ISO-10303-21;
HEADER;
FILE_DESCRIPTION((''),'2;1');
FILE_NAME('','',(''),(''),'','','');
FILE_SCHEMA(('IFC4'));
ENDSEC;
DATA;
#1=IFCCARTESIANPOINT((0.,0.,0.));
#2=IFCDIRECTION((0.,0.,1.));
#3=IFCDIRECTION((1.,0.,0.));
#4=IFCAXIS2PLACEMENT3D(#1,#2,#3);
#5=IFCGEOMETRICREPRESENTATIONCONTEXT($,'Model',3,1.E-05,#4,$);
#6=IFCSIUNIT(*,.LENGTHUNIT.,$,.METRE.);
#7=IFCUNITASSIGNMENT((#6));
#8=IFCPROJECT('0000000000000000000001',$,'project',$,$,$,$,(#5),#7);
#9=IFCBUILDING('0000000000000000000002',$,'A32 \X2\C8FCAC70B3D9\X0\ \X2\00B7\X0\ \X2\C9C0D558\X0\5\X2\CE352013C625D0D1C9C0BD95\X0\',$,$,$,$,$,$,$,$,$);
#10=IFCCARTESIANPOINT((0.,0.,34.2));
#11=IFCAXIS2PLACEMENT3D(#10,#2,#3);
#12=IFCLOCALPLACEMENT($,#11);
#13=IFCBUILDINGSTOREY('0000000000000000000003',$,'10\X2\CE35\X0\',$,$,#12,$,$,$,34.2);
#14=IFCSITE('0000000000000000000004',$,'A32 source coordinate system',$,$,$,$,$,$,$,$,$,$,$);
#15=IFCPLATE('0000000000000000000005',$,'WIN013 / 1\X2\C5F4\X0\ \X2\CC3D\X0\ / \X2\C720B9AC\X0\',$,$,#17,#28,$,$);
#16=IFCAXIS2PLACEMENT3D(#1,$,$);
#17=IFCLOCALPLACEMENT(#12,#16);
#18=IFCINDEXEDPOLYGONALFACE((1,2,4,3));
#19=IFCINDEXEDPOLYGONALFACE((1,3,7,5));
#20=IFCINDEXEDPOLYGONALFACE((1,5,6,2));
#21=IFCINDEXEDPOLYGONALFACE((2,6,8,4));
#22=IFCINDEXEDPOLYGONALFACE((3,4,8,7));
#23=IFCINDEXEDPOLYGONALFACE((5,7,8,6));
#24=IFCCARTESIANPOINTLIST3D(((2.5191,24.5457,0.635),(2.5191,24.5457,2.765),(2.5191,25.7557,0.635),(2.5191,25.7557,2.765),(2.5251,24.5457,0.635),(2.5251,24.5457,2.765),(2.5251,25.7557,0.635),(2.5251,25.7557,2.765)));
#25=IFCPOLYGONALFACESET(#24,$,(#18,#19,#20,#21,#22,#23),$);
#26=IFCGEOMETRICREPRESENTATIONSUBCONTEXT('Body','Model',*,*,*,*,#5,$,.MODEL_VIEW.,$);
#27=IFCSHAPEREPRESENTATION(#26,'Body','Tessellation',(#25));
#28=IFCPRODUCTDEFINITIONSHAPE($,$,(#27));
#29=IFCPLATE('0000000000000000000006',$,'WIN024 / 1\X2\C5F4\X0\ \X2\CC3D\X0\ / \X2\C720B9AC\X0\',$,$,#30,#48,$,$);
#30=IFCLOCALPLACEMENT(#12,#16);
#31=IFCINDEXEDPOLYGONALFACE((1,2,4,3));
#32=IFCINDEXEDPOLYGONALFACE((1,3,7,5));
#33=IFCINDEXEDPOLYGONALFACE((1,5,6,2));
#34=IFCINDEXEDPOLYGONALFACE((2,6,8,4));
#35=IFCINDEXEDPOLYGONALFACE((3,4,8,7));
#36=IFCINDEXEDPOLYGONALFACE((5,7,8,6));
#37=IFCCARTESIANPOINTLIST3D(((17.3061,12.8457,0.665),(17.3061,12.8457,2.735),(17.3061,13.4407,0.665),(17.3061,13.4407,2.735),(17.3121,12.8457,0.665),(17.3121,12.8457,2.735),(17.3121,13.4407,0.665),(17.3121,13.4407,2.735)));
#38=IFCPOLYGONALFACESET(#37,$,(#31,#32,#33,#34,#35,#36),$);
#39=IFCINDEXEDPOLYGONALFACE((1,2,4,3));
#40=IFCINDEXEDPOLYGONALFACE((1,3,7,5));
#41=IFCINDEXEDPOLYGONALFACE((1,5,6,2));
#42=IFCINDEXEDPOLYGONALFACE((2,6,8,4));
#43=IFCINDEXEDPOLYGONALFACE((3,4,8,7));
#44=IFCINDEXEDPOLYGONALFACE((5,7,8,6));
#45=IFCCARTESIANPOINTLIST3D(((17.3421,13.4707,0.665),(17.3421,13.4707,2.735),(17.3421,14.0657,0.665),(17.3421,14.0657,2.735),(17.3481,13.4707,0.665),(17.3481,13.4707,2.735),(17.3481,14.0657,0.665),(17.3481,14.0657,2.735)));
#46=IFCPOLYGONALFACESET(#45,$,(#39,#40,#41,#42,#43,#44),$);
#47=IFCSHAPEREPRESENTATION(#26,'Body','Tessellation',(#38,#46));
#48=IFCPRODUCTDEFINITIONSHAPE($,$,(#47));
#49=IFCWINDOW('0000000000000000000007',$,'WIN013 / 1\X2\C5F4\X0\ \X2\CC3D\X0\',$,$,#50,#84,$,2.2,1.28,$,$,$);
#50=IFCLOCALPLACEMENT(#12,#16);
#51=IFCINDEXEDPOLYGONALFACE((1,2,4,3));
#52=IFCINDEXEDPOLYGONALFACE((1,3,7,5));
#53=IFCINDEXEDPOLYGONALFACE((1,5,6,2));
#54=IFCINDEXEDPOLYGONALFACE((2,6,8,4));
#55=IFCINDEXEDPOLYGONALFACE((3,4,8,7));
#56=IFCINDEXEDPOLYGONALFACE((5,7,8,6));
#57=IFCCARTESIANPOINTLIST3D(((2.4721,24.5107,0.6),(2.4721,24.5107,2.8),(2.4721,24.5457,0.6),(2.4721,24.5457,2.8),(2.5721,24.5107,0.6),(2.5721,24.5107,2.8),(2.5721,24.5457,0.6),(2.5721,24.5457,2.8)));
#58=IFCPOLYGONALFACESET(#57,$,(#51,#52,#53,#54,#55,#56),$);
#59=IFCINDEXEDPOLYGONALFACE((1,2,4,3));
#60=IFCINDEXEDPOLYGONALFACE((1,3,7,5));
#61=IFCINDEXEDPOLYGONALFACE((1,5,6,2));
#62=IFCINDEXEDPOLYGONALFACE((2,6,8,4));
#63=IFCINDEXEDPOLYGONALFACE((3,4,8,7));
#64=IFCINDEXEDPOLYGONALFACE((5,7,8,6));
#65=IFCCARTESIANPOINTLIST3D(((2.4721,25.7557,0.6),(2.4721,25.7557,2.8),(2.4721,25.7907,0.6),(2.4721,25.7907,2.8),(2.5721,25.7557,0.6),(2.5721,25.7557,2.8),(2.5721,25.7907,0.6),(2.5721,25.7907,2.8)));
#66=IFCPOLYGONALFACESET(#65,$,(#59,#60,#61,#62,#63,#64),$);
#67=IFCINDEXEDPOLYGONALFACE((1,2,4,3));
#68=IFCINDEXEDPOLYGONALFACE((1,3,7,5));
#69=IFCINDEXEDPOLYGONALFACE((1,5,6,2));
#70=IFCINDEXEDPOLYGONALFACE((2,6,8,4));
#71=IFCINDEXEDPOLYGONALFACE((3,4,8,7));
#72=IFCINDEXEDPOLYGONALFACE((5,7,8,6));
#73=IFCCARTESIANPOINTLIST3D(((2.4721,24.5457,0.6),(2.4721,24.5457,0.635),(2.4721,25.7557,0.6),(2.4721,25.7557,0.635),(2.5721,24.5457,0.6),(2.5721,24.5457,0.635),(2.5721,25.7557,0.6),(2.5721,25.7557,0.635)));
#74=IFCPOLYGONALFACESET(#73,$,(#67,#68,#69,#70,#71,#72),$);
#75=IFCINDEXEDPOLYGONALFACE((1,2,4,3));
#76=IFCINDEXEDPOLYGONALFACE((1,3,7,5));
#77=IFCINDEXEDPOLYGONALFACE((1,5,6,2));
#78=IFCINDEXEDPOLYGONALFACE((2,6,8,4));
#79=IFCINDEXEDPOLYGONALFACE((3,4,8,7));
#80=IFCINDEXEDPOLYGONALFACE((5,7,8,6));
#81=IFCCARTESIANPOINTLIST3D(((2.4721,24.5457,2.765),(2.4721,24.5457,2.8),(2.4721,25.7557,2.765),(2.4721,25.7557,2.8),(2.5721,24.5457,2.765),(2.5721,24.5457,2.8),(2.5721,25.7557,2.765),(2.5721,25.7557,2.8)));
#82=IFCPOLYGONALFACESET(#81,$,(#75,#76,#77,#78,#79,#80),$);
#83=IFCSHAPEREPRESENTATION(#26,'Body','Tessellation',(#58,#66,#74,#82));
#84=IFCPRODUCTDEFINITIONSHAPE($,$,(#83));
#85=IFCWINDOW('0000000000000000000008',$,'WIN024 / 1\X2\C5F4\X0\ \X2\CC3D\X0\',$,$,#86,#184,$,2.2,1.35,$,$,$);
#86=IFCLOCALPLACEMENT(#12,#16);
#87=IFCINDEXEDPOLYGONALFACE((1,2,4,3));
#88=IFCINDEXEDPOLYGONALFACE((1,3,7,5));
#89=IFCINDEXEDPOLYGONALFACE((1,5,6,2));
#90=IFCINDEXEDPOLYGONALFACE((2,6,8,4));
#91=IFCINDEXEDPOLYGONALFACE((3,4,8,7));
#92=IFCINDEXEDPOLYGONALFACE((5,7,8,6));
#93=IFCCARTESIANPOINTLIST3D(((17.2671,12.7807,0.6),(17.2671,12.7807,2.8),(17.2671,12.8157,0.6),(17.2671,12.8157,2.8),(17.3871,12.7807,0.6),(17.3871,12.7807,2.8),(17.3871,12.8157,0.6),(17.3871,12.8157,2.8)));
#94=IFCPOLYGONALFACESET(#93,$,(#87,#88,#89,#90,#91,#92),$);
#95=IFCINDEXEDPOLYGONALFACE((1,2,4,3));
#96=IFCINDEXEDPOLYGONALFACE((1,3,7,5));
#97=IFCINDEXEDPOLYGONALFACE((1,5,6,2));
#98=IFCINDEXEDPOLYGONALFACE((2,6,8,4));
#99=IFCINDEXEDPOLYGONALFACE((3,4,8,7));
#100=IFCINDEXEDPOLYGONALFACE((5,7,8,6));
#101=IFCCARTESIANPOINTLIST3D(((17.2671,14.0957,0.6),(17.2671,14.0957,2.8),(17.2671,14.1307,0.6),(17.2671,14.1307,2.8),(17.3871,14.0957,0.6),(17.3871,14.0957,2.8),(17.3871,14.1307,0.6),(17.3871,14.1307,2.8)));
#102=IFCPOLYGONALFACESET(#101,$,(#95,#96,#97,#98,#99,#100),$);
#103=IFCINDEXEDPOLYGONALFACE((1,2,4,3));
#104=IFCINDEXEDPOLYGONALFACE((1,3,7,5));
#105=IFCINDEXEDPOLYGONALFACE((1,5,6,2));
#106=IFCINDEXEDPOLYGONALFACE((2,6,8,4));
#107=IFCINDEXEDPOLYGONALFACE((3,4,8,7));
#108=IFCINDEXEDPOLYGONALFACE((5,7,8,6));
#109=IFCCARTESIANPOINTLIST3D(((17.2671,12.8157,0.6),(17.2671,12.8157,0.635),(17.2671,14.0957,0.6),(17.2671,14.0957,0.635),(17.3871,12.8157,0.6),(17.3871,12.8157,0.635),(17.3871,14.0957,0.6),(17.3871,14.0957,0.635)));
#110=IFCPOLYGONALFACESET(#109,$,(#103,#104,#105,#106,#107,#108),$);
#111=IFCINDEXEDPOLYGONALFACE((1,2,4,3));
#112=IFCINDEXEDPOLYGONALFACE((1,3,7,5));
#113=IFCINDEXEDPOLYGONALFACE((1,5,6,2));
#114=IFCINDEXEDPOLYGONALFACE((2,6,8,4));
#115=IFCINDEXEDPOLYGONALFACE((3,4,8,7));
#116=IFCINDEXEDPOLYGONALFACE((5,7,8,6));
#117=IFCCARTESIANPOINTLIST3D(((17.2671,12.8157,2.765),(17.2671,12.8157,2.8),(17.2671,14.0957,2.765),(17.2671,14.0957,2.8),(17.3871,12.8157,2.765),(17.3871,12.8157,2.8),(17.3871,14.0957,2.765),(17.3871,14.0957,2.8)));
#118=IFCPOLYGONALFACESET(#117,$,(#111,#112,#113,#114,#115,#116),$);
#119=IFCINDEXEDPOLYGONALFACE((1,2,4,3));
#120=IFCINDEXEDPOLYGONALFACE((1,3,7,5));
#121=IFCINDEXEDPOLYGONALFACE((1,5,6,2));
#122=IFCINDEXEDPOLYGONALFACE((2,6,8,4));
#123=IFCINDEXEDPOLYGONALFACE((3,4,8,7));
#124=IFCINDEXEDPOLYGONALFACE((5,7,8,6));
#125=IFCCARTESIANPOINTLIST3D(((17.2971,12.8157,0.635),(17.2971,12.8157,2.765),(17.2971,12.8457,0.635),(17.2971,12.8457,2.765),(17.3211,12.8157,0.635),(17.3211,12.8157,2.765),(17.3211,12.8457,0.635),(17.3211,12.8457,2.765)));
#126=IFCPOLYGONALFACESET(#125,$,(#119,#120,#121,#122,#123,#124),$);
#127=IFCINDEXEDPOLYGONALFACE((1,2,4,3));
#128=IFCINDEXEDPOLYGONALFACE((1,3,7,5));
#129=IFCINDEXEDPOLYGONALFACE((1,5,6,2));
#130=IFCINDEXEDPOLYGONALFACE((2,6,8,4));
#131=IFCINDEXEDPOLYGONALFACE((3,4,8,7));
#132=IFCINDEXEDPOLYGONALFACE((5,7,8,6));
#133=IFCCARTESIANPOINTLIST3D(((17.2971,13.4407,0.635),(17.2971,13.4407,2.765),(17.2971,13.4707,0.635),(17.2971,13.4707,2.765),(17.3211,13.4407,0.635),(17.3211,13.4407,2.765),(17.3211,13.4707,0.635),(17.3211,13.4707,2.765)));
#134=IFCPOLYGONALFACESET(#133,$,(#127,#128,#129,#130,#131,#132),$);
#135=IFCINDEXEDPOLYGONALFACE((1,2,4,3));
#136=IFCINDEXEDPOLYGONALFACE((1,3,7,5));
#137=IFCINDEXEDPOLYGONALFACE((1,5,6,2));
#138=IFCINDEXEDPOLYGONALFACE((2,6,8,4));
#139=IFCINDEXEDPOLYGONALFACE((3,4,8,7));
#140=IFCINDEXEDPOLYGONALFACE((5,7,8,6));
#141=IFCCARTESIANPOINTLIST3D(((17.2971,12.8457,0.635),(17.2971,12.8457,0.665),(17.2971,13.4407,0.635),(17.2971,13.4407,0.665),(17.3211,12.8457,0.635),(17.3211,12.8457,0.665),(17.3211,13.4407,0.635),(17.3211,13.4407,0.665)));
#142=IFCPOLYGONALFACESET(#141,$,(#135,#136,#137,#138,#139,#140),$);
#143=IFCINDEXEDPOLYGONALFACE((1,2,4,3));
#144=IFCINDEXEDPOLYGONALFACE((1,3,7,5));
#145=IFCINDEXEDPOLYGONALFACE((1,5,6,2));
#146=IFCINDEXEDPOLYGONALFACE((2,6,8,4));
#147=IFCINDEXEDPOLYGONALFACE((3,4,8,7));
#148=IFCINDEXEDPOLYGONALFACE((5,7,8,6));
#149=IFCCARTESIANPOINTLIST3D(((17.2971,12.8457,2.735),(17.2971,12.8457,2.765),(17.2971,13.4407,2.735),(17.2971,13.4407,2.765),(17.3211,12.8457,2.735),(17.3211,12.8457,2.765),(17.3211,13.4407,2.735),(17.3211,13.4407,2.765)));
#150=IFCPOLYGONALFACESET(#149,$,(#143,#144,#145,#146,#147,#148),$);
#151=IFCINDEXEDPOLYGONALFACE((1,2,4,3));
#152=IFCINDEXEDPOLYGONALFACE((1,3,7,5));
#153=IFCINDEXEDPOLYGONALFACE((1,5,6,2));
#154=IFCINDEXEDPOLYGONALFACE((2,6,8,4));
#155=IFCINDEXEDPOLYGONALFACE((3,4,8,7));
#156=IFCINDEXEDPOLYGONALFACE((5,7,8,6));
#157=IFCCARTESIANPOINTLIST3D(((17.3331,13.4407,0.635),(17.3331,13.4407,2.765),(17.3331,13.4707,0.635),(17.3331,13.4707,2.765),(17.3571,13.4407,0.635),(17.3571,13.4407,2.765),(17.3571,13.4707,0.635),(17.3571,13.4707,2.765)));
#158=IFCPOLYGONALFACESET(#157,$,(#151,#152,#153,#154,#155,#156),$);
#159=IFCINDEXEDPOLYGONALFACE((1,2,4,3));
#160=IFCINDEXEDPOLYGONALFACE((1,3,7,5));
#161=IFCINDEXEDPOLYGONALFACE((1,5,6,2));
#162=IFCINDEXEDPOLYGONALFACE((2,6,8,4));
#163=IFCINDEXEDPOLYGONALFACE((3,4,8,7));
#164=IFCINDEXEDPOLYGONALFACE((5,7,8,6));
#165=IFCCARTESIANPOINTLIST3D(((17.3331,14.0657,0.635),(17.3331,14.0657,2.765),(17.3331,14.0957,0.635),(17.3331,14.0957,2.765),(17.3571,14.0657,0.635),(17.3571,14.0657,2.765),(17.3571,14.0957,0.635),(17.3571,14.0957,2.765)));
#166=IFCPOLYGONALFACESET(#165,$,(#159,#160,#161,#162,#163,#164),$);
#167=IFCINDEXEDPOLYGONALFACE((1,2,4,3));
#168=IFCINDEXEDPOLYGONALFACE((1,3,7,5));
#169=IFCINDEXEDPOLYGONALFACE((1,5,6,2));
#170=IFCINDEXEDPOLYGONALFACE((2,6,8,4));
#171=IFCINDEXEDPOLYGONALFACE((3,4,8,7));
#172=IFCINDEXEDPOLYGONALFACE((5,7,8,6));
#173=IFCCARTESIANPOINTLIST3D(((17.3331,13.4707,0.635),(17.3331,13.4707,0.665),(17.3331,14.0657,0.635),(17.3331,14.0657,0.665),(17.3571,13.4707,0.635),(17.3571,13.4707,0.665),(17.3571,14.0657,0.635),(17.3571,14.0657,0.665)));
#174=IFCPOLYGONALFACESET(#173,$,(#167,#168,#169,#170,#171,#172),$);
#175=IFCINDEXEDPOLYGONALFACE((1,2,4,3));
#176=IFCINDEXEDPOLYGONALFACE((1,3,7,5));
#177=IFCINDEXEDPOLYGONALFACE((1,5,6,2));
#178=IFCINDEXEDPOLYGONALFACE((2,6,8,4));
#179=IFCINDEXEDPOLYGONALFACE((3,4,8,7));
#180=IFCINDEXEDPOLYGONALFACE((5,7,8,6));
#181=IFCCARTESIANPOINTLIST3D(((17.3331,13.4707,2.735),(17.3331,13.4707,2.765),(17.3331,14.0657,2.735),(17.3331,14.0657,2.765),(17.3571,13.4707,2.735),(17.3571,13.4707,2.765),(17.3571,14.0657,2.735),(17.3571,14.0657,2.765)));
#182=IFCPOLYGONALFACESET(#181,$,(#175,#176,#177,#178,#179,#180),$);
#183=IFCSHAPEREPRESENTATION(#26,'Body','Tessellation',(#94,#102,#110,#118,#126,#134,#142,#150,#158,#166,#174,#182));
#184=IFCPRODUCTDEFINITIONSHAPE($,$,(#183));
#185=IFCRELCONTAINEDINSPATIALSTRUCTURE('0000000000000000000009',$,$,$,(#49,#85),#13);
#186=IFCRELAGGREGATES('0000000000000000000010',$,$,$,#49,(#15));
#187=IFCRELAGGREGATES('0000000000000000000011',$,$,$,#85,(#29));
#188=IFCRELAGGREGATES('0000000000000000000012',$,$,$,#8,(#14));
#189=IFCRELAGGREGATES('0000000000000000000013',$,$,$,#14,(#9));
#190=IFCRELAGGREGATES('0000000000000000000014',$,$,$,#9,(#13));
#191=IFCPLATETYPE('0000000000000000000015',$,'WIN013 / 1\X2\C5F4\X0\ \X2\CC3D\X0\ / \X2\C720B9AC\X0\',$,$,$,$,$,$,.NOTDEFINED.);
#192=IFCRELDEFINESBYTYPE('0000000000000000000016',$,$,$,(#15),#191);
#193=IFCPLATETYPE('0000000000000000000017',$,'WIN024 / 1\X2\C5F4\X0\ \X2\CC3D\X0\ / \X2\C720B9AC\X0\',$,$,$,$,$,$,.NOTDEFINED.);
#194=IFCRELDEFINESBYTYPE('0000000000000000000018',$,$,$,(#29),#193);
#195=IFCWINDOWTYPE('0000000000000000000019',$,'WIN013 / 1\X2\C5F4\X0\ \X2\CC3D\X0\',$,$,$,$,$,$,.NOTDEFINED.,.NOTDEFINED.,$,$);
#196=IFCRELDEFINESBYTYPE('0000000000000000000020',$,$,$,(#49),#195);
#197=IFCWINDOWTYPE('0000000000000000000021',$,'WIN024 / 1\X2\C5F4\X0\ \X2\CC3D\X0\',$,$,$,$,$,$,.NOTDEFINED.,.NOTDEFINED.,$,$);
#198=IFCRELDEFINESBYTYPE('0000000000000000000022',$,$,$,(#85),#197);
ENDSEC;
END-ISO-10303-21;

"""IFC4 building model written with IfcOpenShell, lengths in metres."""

from ifc_helpers import new_model, si_unit, frame, origin, origin_with_axes, place, context, subcontext, project, spatial, polyline, outline, extrude, source, transform, mapped, type_object, type_shapes, element, aggregate, save


model = new_model("IFC4")

# Units and contexts
model_context = context("Model", 3, precision=1e-05, world=origin_with_axes())
body_context = subcontext(model_context, "Body", "Model", "MODEL_VIEW")
ifc_project = project(units=[si_unit("LENGTHUNIT", "METRE")], contexts=[model_context])

# Plates
plate_type_1 = type_object("IfcPlateType", Name="WIN013 / 1열 창 / 유리", PredefinedType="NOTDEFINED")
shared_shape_1 = source(origin(), body_context, "Body", "SweptSolid", [
    extrude(outline(polyline([(2.5191, 24.5457), (2.5191, 25.7557), (2.5251, 25.7557), (2.5251, 24.5457), (2.5191, 24.5457)])), frame((0.0, 0.0, 0.635)), (0.0, 0.0, 1.0), 2.13),
])
type_shapes(plate_type_1, [shared_shape_1])
storey_placement = place(None, frame((0.0, 0.0, 34.2), z_axis=(0.0, 0.0, 1.0), x_axis=(1.0, 0.0, 0.0)))
window_1_placement = place(storey_placement, origin_with_axes())
plate_1_placement = place(window_1_placement, origin_with_axes())
plate_1 = element("IfcPlate", 1, at=plate_1_placement, type_object=plate_type_1, Name="WIN013 / 1열 창 / 유리", context=body_context, shape_type="MappedRepresentation", body=[
    mapped(shared_shape_1, transform((0.0, 0.0, 0.0), scale=1.0)),
])
plate_type_2 = type_object("IfcPlateType", Name="WIN024 / 1열 창 / 유리", PredefinedType="NOTDEFINED")
shared_shape_2 = source(origin(), body_context, "Body", "SweptSolid", [
    extrude(outline(polyline([(17.3061, 12.8457), (17.3061, 13.4407), (17.3121, 13.4407), (17.3121, 12.8457), (17.3061, 12.8457)])), frame((0.0, 0.0, 0.665)), (0.0, 0.0, 1.0), 2.07),
    extrude(outline(polyline([(17.3421, 13.4707), (17.3421, 14.0657), (17.3481, 14.0657), (17.3481, 13.4707), (17.3421, 13.4707)])), frame((0.0, 0.0, 0.665)), (0.0, 0.0, 1.0), 2.07),
])
type_shapes(plate_type_2, [shared_shape_2])
window_2_placement = place(storey_placement, origin_with_axes())
plate_2_placement = place(window_2_placement, origin_with_axes())
plate_2 = element("IfcPlate", 2, at=plate_2_placement, type_object=plate_type_2, Name="WIN024 / 1열 창 / 유리", context=body_context, shape_type="MappedRepresentation", body=[
    mapped(shared_shape_2, transform((0.0, 0.0, 0.0), scale=1.0)),
])

# Site, building, storey
site = spatial("IfcSite", under=ifc_project, Name="A32 source coordinate system")
building = spatial("IfcBuilding", under=site, Name="A32 주거동 · 지하5층–옥탑지붕")
storey = spatial("IfcBuildingStorey", under=building, at=storey_placement, Name="10층", Elevation=34.2)

# Windows
window_type_1 = type_object("IfcWindowType", Name="WIN013 / 1열 창", PartitioningType="NOTDEFINED", PredefinedType="NOTDEFINED")
shared_shape_3 = source(origin(), body_context, "Body", "SweptSolid", [
    extrude(outline(polyline([(2.4721, 24.5107), (2.4721, 24.5457), (2.5721, 24.5457), (2.5721, 24.5107), (2.4721, 24.5107)])), frame((0.0, 0.0, 0.6)), (0.0, 0.0, 1.0), 2.2),
    extrude(outline(polyline([(2.4721, 25.7557), (2.4721, 25.7907), (2.5721, 25.7907), (2.5721, 25.7557), (2.4721, 25.7557)])), frame((0.0, 0.0, 0.6)), (0.0, 0.0, 1.0), 2.2),
    extrude(outline(polyline([(2.4721, 24.5457), (2.4721, 25.7557), (2.5721, 25.7557), (2.5721, 24.5457), (2.4721, 24.5457)])), frame((0.0, 0.0, 0.6)), (0.0, 0.0, 1.0), 0.035),
    extrude(outline(polyline([(2.4721, 24.5457), (2.4721, 25.7557), (2.5721, 25.7557), (2.5721, 24.5457), (2.4721, 24.5457)])), frame((0.0, 0.0, 2.765)), (0.0, 0.0, 1.0), 0.035),
])
type_shapes(window_type_1, [shared_shape_3])
window_1 = element("IfcWindow", 3, at=window_1_placement, inside=storey, type_object=window_type_1, Name="WIN013 / 1열 창", OverallHeight=2.2, OverallWidth=1.28, context=body_context, shape_type="MappedRepresentation", body=[
    mapped(shared_shape_3, transform((0.0, 0.0, 0.0), scale=1.0)),
])
aggregate(window_1, [plate_1])
window_type_2 = type_object("IfcWindowType", Name="WIN024 / 1열 창", PartitioningType="NOTDEFINED", PredefinedType="NOTDEFINED")
shared_shape_4 = source(origin(), body_context, "Body", "SweptSolid", [
    extrude(outline(polyline([(17.2671, 12.7807), (17.2671, 12.8157), (17.3871, 12.8157), (17.3871, 12.7807), (17.2671, 12.7807)])), frame((0.0, 0.0, 0.6)), (0.0, 0.0, 1.0), 2.2),
    extrude(outline(polyline([(17.2671, 14.0957), (17.2671, 14.1307), (17.3871, 14.1307), (17.3871, 14.0957), (17.2671, 14.0957)])), frame((0.0, 0.0, 0.6)), (0.0, 0.0, 1.0), 2.2),
    extrude(outline(polyline([(17.2671, 12.8157), (17.2671, 14.0957), (17.3871, 14.0957), (17.3871, 12.8157), (17.2671, 12.8157)])), frame((0.0, 0.0, 0.6)), (0.0, 0.0, 1.0), 0.035),
    extrude(outline(polyline([(17.2671, 12.8157), (17.2671, 14.0957), (17.3871, 14.0957), (17.3871, 12.8157), (17.2671, 12.8157)])), frame((0.0, 0.0, 2.765)), (0.0, 0.0, 1.0), 0.035),
    extrude(outline(polyline([(17.2971, 12.8157), (17.2971, 12.8457), (17.3211, 12.8457), (17.3211, 12.8157), (17.2971, 12.8157)])), frame((0.0, 0.0, 0.635)), (0.0, 0.0, 1.0), 2.13),
    extrude(outline(polyline([(17.2971, 13.4407), (17.2971, 13.4707), (17.3211, 13.4707), (17.3211, 13.4407), (17.2971, 13.4407)])), frame((0.0, 0.0, 0.635)), (0.0, 0.0, 1.0), 2.13),
    extrude(outline(polyline([(17.2971, 12.8457), (17.2971, 13.4407), (17.3211, 13.4407), (17.3211, 12.8457), (17.2971, 12.8457)])), frame((0.0, 0.0, 0.635)), (0.0, 0.0, 1.0), 0.03),
    extrude(outline(polyline([(17.2971, 12.8457), (17.2971, 13.4407), (17.3211, 13.4407), (17.3211, 12.8457), (17.2971, 12.8457)])), frame((0.0, 0.0, 2.735)), (0.0, 0.0, 1.0), 0.03),
    extrude(outline(polyline([(17.3331, 13.4407), (17.3331, 13.4707), (17.3571, 13.4707), (17.3571, 13.4407), (17.3331, 13.4407)])), frame((0.0, 0.0, 0.635)), (0.0, 0.0, 1.0), 2.13),
    extrude(outline(polyline([(17.3331, 14.0657), (17.3331, 14.0957), (17.3571, 14.0957), (17.3571, 14.0657), (17.3331, 14.0657)])), frame((0.0, 0.0, 0.635)), (0.0, 0.0, 1.0), 2.13),
    extrude(outline(polyline([(17.3331, 13.4707), (17.3331, 14.0657), (17.3571, 14.0657), (17.3571, 13.4707), (17.3331, 13.4707)])), frame((0.0, 0.0, 0.635)), (0.0, 0.0, 1.0), 0.03),
    extrude(outline(polyline([(17.3331, 13.4707), (17.3331, 14.0657), (17.3571, 14.0657), (17.3571, 13.4707), (17.3331, 13.4707)])), frame((0.0, 0.0, 2.735)), (0.0, 0.0, 1.0), 0.03),
])
type_shapes(window_type_2, [shared_shape_4])
window_2 = element("IfcWindow", 4, at=window_2_placement, inside=storey, type_object=window_type_2, Name="WIN024 / 1열 창", OverallHeight=2.2, OverallWidth=1.35, context=body_context, shape_type="MappedRepresentation", body=[
    mapped(shared_shape_4, transform((0.0, 0.0, 0.0), scale=1.0)),
])
aggregate(window_2, [plate_2])

save(model, "model.ifc")
